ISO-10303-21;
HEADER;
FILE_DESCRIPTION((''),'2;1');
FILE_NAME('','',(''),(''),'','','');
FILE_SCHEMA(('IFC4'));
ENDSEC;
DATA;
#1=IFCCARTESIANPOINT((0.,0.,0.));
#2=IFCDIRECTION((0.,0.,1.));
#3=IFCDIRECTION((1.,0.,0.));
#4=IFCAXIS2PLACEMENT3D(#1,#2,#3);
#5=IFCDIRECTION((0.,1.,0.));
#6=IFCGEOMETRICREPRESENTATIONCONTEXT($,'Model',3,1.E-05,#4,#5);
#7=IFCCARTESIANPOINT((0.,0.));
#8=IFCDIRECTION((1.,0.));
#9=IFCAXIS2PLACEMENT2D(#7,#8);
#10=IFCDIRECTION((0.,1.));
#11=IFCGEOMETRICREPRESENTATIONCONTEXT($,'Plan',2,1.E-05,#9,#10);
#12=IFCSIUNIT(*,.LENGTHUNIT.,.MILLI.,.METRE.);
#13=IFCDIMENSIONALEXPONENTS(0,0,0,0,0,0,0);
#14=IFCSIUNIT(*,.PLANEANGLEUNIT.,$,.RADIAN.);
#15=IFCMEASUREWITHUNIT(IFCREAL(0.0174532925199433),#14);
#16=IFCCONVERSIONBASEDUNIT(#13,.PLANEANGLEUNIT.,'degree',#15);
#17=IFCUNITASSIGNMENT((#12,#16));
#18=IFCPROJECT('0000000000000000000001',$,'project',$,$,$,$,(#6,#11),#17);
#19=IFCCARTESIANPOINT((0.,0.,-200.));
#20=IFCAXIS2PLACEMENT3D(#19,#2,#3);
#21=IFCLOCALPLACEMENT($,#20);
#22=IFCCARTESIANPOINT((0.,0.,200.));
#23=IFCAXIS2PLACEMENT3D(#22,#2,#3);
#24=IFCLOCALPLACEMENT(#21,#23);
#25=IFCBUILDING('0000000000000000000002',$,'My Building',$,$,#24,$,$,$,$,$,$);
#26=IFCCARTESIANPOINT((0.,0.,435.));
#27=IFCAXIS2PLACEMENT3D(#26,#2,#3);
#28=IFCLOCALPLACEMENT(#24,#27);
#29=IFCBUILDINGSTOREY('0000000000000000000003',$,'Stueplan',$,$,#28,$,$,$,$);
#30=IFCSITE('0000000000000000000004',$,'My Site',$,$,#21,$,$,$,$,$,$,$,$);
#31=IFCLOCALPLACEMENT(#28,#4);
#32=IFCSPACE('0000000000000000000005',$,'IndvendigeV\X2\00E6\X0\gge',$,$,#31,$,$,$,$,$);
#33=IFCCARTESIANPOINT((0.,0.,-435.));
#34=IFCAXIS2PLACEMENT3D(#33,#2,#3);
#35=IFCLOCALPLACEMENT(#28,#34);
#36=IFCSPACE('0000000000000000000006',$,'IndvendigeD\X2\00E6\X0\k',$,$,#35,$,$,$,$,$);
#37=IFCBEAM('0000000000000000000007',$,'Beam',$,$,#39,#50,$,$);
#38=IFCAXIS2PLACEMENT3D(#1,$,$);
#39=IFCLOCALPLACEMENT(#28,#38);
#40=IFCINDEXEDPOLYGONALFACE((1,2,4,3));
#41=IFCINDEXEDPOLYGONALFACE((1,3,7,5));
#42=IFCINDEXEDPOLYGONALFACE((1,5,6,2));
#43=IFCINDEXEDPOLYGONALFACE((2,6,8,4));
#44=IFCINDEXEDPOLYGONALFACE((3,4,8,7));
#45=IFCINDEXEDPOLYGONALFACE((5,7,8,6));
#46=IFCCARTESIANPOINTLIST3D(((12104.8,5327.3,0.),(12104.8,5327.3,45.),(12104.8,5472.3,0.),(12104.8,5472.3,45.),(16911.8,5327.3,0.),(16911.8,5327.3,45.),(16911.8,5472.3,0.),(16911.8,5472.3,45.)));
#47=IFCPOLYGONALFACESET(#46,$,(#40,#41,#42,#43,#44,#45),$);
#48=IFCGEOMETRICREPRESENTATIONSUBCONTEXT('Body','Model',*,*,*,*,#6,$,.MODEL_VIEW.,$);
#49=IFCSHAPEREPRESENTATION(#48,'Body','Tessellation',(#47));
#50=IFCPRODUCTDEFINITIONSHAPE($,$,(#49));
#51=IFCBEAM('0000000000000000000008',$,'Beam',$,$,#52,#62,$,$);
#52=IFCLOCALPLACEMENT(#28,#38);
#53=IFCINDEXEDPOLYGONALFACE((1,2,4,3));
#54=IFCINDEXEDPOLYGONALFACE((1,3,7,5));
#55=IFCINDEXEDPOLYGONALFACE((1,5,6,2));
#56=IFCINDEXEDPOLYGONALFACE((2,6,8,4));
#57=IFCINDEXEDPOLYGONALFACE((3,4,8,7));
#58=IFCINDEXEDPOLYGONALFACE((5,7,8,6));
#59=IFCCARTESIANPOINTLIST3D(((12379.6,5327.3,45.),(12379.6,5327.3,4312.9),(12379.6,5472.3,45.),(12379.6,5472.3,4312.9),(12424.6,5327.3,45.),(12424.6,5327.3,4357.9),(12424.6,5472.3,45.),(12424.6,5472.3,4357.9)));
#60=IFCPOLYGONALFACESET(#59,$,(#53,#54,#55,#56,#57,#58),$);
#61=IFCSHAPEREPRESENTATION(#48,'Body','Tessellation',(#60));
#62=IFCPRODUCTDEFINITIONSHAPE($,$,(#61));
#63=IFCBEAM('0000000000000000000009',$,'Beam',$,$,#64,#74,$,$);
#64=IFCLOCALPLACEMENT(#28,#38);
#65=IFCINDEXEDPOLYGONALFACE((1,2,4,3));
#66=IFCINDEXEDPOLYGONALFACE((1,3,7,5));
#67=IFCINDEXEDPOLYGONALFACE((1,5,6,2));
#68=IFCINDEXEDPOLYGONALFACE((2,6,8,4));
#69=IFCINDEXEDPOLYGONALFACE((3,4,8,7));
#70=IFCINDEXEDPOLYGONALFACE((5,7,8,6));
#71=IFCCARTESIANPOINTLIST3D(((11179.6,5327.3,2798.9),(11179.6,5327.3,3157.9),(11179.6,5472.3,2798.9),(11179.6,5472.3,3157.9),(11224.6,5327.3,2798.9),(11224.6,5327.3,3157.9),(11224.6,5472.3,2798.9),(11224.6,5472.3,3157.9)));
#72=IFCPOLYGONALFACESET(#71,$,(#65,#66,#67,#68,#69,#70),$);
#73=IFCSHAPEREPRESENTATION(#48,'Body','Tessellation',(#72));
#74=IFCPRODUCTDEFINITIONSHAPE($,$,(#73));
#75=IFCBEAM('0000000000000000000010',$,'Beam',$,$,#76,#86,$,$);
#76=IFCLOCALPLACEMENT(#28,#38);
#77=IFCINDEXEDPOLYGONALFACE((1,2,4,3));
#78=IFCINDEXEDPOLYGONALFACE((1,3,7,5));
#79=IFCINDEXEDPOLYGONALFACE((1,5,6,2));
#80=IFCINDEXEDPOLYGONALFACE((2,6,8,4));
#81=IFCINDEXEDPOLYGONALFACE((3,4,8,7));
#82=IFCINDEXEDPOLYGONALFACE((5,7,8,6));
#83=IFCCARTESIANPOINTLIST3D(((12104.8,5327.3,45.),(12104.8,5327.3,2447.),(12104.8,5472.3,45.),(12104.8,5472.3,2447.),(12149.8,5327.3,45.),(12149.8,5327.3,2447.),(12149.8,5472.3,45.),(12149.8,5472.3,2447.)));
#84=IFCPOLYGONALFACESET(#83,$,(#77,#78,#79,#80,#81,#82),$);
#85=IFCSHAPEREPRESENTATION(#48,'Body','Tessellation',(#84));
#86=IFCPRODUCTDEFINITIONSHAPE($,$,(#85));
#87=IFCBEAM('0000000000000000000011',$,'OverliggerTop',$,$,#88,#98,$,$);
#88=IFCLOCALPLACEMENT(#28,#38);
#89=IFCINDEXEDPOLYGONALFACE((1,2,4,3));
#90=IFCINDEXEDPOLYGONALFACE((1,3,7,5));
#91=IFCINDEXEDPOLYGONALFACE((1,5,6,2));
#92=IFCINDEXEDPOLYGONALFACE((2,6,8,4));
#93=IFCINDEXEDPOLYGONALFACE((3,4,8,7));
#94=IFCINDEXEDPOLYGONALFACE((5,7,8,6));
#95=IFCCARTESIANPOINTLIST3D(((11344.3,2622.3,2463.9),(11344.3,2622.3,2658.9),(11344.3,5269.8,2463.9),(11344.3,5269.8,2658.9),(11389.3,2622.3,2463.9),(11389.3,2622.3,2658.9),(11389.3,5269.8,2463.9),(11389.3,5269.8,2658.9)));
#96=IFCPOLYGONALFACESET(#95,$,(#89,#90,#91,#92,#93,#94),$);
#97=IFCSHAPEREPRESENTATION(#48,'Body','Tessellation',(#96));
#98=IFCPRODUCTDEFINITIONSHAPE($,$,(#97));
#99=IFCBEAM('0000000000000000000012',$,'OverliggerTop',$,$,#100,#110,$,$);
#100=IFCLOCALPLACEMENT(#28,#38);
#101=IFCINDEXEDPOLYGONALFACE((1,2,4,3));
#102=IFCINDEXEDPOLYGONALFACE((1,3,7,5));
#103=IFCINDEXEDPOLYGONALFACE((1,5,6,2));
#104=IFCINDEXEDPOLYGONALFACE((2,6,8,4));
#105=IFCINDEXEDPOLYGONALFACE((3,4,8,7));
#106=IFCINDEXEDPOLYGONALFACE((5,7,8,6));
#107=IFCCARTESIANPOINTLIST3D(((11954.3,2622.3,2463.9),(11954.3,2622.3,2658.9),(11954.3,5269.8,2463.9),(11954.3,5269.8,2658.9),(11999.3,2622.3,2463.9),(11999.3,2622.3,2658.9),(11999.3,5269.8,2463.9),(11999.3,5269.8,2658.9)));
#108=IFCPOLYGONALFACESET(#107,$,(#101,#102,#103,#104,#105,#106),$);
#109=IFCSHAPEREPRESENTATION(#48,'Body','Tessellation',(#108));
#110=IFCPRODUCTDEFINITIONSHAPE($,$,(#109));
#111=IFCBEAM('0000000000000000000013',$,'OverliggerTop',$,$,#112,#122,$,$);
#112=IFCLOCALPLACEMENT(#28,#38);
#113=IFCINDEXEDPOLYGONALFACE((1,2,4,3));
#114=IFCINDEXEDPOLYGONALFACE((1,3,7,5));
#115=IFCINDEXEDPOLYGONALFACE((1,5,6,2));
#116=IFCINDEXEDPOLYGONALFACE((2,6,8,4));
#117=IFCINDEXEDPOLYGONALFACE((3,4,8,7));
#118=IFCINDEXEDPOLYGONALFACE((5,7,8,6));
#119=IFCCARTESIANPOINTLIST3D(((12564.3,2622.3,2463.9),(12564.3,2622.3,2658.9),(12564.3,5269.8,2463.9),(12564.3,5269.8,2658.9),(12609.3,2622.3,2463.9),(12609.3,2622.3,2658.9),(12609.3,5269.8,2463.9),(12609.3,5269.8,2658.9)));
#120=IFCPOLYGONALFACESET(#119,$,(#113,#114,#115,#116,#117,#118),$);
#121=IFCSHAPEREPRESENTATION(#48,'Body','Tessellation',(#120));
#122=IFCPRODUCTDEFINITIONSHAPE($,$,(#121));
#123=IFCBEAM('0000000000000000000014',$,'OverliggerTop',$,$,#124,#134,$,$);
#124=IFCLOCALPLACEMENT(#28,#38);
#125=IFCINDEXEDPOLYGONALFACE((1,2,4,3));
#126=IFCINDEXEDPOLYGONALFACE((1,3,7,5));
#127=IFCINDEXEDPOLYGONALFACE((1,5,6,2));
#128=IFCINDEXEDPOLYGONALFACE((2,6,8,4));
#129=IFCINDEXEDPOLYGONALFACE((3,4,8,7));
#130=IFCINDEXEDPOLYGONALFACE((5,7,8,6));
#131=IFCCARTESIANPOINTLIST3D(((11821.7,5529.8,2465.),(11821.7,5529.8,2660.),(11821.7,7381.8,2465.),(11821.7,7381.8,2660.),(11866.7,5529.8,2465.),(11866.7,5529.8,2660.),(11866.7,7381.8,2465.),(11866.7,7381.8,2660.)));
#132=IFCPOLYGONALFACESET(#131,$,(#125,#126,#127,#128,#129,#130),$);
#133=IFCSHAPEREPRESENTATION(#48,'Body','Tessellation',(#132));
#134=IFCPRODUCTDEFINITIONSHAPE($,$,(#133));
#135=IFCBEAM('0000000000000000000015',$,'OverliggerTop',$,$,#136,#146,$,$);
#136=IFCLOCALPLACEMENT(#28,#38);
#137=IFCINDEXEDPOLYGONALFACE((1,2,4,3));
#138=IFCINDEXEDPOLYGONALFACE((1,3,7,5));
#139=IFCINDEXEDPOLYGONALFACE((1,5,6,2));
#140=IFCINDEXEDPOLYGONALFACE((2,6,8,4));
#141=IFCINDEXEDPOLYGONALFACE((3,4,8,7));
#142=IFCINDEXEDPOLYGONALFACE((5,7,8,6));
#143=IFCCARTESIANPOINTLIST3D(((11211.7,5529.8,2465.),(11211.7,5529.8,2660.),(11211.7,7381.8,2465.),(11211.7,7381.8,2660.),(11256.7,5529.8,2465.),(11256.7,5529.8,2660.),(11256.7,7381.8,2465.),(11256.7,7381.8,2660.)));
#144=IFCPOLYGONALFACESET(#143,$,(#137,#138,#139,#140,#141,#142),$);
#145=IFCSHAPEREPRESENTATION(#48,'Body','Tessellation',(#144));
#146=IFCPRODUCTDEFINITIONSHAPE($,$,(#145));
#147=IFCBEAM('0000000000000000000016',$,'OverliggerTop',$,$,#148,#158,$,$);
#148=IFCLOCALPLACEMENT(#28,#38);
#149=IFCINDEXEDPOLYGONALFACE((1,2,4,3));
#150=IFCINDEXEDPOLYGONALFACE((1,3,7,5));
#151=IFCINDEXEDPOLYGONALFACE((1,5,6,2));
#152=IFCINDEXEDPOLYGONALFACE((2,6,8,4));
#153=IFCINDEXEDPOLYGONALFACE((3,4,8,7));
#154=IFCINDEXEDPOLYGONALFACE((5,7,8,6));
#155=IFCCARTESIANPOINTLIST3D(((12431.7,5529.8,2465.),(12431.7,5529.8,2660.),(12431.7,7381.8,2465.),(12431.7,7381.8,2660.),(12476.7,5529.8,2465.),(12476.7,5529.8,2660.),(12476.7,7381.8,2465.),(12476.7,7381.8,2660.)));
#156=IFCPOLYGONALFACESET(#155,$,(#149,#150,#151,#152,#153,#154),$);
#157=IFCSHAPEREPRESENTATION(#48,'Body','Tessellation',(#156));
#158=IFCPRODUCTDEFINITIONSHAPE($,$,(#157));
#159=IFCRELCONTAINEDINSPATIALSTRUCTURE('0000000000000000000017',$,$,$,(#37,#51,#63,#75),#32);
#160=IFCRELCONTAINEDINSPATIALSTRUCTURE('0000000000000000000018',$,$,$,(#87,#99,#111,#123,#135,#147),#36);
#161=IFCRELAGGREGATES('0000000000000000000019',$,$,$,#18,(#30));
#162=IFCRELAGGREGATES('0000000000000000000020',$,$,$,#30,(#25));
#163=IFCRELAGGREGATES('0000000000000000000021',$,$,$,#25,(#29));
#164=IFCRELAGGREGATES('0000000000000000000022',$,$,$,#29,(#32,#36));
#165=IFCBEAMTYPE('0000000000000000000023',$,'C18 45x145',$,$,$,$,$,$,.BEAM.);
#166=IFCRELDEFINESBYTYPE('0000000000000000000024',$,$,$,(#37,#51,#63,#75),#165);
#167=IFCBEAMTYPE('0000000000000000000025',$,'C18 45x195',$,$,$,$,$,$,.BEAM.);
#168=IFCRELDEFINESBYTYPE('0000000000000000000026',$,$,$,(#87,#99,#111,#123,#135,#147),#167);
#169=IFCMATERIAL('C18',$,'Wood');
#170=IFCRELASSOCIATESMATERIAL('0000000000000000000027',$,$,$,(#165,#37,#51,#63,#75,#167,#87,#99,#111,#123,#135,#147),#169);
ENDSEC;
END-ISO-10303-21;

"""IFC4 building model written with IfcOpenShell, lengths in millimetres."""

from ifc_helpers import new_model, entity, si_unit, converted_unit, direction, frame, origin_with_axes, origin_2d_with_axis, place, context, subcontext, project, spatial, rectangle, extrude, clip, halfspace, material, material_profile, profile_set, profile_usage, type_object, element, save


model = new_model("IFC4")

# Units and contexts
model_context = context("Model", 3, precision=1e-05, world=origin_with_axes(), true_north=direction((0.0, 1.0, 0.0)))
plan_context = context("Plan", 2, precision=1e-05, world=origin_2d_with_axis(), true_north=direction((0.0, 1.0)))
body_context_1 = subcontext(model_context, "Body", "Model", "MODEL_VIEW")
ifc_project = project(units=[si_unit("LENGTHUNIT", "METRE", prefix="MILLI"), converted_unit("PLANEANGLEUNIT", "degree", entity("IfcReal", 0.0174532925199433), si_unit("PLANEANGLEUNIT", "RADIAN"), dimensions=[0, 0, 0, 0, 0, 0, 0])], contexts=[model_context, plan_context])

# Site, building, storey, space
site_placement = place(None, frame((0.0, 0.0, -200.0), z_axis=(0.0, 0.0, 1.0), x_axis=(1.0, 0.0, 0.0)))
site = spatial("IfcSite", under=ifc_project, at=site_placement, Name="My Site")
building_placement = place(site_placement, frame((0.0, 0.0, 200.0), z_axis=(0.0, 0.0, 1.0), x_axis=(1.0, 0.0, 0.0)))
building = spatial("IfcBuilding", under=site, at=building_placement, Name="My Building")
storey_placement = place(building_placement, frame((0.0, 0.0, 435.0), z_axis=(0.0, 0.0, 1.0), x_axis=(1.0, 0.0, 0.0)))
storey = spatial("IfcBuildingStorey", under=building, at=storey_placement, Name="Stueplan")
space_1_placement = place(storey_placement, frame((0.0, 0.0, 0.0), z_axis=(0.0, 0.0, 1.0), x_axis=(1.0, 0.0, 0.0)))
space_1 = spatial("IfcSpace", under=storey, at=space_1_placement, Name="IndvendigeVægge")

# Beams
ifc_material = material(Name="C18", Category="Wood")
ifc_material_profile_1 = material_profile(ifc_material, rectangle(XDim=45.0, YDim=145.0))
ifc_profile_set_1 = profile_set([ifc_material_profile_1], Name="woodStructural")
beam_type_1 = type_object("IfcBeamType", Name="C18 45x145", PredefinedType="BEAM", material=ifc_profile_set_1)
ifc_profile_usage_1 = profile_usage(ifc_profile_set_1)
beam_1_placement = place(space_1_placement, frame((12104.8, 5399.8, 22.5), z_axis=(1.0, 0.0, 0.0), x_axis=(0.0, 0.0, 1.0)))
element("IfcBeam", 1, at=beam_1_placement, inside=space_1, type_object=beam_type_1, material=ifc_profile_usage_1, Name="Beam", context=body_context_1, shape_type="SweptSolid", body=[
    extrude(rectangle(XDim=45.0, YDim=145.0), origin_with_axes(), (0.0, 0.0, 1.0), 4807.0),
])
ifc_profile_usage_2 = profile_usage(ifc_profile_set_1)
beam_2_placement = place(space_1_placement, frame((12402.1, 5399.8, 45.0), z_axis=(0.0, 0.0, 1.0), x_axis=(-1.0, 0.0, 0.0)))
element("IfcBeam", 2, at=beam_2_placement, inside=space_1, type_object=beam_type_1, material=ifc_profile_usage_2, Name="Beam", context=body_context_1, shape_type="Clipping", body=[
    clip(extrude(rectangle(XDim=45.0, YDim=145.0), origin_with_axes(), (0.0, 0.0, 1.0), 4435.4), halfspace(frame((-1439.0, 0.0, 5729.4), z_axis=(0.707107, 0.0, 0.707107), x_axis=(0.0, -1.0, 0.0)), False)),
])
ifc_profile_usage_3 = profile_usage(ifc_profile_set_1)
beam_3_placement = place(space_1_placement, frame((11202.1, 5399.8, 2798.9), z_axis=(0.0, 0.0, 1.0), x_axis=(-1.0, 0.0, 0.0)))
element("IfcBeam", 3, at=beam_3_placement, inside=space_1, type_object=beam_type_1, material=ifc_profile_usage_3, Name="Beam", context=body_context_1, shape_type="SweptSolid", body=[
    extrude(rectangle(XDim=45.0, YDim=145.0), origin_with_axes(), (0.0, 0.0, 1.0), 358.9),
])
ifc_profile_usage_4 = profile_usage(ifc_profile_set_1)
beam_4_placement = place(space_1_placement, frame((12127.3, 5399.8, 45.0), z_axis=(0.0, 0.0, 1.0), x_axis=(-1.0, 0.0, 0.0)))
element("IfcBeam", 4, at=beam_4_placement, inside=space_1, type_object=beam_type_1, material=ifc_profile_usage_4, Name="Beam", context=body_context_1, shape_type="SweptSolid", body=[
    extrude(rectangle(XDim=45.0, YDim=145.0), origin_with_axes(), (0.0, 0.0, 1.0), 2402.0),
])

# Shared definitions
space_2_placement = place(storey_placement, frame((0.0, 0.0, -435.0), z_axis=(0.0, 0.0, 1.0), x_axis=(1.0, 0.0, 0.0)))
space_2 = spatial("IfcSpace", under=storey, at=space_2_placement, Name="IndvendigeDæk")

# Beams
ifc_material_profile_2 = material_profile(ifc_material, rectangle(XDim=45.0, YDim=195.0))
ifc_profile_set_2 = profile_set([ifc_material_profile_2], Name="woodStructural")
ifc_profile_usage_5 = profile_usage(ifc_profile_set_2)
beam_type_2 = type_object("IfcBeamType", Name="C18 45x195", PredefinedType="BEAM", material=ifc_profile_set_2)
beam_5_placement = place(space_2_placement, frame((11366.8, 5269.8, 2996.4), z_axis=(0.000001, -1.0, 0.0), x_axis=(-1.0, -0.000001, 0.0)))
element("IfcBeam", 5, at=beam_5_placement, inside=space_2, type_object=beam_type_2, material=ifc_profile_usage_5, Name="OverliggerTop", context=body_context_1, shape_type="SweptSolid", body=[
    extrude(rectangle(XDim=45.0, YDim=195.0), origin_with_axes(), (0.0, 0.0, 1.0), 2647.5),
])
ifc_profile_usage_6 = profile_usage(ifc_profile_set_2)
beam_6_placement = place(space_2_placement, frame((11976.8, 5269.8, 2996.4), z_axis=(0.000001, -1.0, 0.0), x_axis=(-1.0, -0.000001, 0.0)))
element("IfcBeam", 6, at=beam_6_placement, inside=space_2, type_object=beam_type_2, material=ifc_profile_usage_6, Name="OverliggerTop", context=body_context_1, shape_type="SweptSolid", body=[
    extrude(rectangle(XDim=45.0, YDim=195.0), origin_with_axes(), (0.0, 0.0, 1.0), 2647.5),
])
ifc_profile_usage_7 = profile_usage(ifc_profile_set_2)
beam_7_placement = place(space_2_placement, frame((12586.8, 5269.8, 2996.4), z_axis=(0.000001, -1.0, 0.0), x_axis=(-1.0, -0.000001, 0.0)))
element("IfcBeam", 7, at=beam_7_placement, inside=space_2, type_object=beam_type_2, material=ifc_profile_usage_7, Name="OverliggerTop", context=body_context_1, shape_type="SweptSolid", body=[
    extrude(rectangle(XDim=45.0, YDim=195.0), origin_with_axes(), (0.0, 0.0, 1.0), 2647.5),
])
ifc_profile_usage_8 = profile_usage(ifc_profile_set_2)
beam_8_placement = place(space_2_placement, frame((11844.2, 7381.8, 2997.5), z_axis=(0.000001, -1.0, 0.0), x_axis=(-1.0, -0.000001, 0.0)))
element("IfcBeam", 8, at=beam_8_placement, inside=space_2, type_object=beam_type_2, material=ifc_profile_usage_8, Name="OverliggerTop", context=body_context_1, shape_type="SweptSolid", body=[
    extrude(rectangle(XDim=45.0, YDim=195.0), origin_with_axes(), (0.0, 0.0, 1.0), 1852.0),
])
ifc_profile_usage_9 = profile_usage(ifc_profile_set_2)
beam_9_placement = place(space_2_placement, frame((11234.2, 7381.8, 2997.5), z_axis=(0.000001, -1.0, 0.0), x_axis=(-1.0, -0.000001, 0.0)))
element("IfcBeam", 9, at=beam_9_placement, inside=space_2, type_object=beam_type_2, material=ifc_profile_usage_9, Name="OverliggerTop", context=body_context_1, shape_type="SweptSolid", body=[
    extrude(rectangle(XDim=45.0, YDim=195.0), origin_with_axes(), (0.0, 0.0, 1.0), 1852.0),
])
ifc_profile_usage_10 = profile_usage(ifc_profile_set_2)
beam_10_placement = place(space_2_placement, frame((12454.2, 7381.8, 2997.5), z_axis=(0.000001, -1.0, 0.0), x_axis=(-1.0, -0.000001, 0.0)))
element("IfcBeam", 10, at=beam_10_placement, inside=space_2, type_object=beam_type_2, material=ifc_profile_usage_10, Name="OverliggerTop", context=body_context_1, shape_type="SweptSolid", body=[
    extrude(rectangle(XDim=45.0, YDim=195.0), origin_with_axes(), (0.0, 0.0, 1.0), 1852.0),
])

save(model, "model.ifc")
